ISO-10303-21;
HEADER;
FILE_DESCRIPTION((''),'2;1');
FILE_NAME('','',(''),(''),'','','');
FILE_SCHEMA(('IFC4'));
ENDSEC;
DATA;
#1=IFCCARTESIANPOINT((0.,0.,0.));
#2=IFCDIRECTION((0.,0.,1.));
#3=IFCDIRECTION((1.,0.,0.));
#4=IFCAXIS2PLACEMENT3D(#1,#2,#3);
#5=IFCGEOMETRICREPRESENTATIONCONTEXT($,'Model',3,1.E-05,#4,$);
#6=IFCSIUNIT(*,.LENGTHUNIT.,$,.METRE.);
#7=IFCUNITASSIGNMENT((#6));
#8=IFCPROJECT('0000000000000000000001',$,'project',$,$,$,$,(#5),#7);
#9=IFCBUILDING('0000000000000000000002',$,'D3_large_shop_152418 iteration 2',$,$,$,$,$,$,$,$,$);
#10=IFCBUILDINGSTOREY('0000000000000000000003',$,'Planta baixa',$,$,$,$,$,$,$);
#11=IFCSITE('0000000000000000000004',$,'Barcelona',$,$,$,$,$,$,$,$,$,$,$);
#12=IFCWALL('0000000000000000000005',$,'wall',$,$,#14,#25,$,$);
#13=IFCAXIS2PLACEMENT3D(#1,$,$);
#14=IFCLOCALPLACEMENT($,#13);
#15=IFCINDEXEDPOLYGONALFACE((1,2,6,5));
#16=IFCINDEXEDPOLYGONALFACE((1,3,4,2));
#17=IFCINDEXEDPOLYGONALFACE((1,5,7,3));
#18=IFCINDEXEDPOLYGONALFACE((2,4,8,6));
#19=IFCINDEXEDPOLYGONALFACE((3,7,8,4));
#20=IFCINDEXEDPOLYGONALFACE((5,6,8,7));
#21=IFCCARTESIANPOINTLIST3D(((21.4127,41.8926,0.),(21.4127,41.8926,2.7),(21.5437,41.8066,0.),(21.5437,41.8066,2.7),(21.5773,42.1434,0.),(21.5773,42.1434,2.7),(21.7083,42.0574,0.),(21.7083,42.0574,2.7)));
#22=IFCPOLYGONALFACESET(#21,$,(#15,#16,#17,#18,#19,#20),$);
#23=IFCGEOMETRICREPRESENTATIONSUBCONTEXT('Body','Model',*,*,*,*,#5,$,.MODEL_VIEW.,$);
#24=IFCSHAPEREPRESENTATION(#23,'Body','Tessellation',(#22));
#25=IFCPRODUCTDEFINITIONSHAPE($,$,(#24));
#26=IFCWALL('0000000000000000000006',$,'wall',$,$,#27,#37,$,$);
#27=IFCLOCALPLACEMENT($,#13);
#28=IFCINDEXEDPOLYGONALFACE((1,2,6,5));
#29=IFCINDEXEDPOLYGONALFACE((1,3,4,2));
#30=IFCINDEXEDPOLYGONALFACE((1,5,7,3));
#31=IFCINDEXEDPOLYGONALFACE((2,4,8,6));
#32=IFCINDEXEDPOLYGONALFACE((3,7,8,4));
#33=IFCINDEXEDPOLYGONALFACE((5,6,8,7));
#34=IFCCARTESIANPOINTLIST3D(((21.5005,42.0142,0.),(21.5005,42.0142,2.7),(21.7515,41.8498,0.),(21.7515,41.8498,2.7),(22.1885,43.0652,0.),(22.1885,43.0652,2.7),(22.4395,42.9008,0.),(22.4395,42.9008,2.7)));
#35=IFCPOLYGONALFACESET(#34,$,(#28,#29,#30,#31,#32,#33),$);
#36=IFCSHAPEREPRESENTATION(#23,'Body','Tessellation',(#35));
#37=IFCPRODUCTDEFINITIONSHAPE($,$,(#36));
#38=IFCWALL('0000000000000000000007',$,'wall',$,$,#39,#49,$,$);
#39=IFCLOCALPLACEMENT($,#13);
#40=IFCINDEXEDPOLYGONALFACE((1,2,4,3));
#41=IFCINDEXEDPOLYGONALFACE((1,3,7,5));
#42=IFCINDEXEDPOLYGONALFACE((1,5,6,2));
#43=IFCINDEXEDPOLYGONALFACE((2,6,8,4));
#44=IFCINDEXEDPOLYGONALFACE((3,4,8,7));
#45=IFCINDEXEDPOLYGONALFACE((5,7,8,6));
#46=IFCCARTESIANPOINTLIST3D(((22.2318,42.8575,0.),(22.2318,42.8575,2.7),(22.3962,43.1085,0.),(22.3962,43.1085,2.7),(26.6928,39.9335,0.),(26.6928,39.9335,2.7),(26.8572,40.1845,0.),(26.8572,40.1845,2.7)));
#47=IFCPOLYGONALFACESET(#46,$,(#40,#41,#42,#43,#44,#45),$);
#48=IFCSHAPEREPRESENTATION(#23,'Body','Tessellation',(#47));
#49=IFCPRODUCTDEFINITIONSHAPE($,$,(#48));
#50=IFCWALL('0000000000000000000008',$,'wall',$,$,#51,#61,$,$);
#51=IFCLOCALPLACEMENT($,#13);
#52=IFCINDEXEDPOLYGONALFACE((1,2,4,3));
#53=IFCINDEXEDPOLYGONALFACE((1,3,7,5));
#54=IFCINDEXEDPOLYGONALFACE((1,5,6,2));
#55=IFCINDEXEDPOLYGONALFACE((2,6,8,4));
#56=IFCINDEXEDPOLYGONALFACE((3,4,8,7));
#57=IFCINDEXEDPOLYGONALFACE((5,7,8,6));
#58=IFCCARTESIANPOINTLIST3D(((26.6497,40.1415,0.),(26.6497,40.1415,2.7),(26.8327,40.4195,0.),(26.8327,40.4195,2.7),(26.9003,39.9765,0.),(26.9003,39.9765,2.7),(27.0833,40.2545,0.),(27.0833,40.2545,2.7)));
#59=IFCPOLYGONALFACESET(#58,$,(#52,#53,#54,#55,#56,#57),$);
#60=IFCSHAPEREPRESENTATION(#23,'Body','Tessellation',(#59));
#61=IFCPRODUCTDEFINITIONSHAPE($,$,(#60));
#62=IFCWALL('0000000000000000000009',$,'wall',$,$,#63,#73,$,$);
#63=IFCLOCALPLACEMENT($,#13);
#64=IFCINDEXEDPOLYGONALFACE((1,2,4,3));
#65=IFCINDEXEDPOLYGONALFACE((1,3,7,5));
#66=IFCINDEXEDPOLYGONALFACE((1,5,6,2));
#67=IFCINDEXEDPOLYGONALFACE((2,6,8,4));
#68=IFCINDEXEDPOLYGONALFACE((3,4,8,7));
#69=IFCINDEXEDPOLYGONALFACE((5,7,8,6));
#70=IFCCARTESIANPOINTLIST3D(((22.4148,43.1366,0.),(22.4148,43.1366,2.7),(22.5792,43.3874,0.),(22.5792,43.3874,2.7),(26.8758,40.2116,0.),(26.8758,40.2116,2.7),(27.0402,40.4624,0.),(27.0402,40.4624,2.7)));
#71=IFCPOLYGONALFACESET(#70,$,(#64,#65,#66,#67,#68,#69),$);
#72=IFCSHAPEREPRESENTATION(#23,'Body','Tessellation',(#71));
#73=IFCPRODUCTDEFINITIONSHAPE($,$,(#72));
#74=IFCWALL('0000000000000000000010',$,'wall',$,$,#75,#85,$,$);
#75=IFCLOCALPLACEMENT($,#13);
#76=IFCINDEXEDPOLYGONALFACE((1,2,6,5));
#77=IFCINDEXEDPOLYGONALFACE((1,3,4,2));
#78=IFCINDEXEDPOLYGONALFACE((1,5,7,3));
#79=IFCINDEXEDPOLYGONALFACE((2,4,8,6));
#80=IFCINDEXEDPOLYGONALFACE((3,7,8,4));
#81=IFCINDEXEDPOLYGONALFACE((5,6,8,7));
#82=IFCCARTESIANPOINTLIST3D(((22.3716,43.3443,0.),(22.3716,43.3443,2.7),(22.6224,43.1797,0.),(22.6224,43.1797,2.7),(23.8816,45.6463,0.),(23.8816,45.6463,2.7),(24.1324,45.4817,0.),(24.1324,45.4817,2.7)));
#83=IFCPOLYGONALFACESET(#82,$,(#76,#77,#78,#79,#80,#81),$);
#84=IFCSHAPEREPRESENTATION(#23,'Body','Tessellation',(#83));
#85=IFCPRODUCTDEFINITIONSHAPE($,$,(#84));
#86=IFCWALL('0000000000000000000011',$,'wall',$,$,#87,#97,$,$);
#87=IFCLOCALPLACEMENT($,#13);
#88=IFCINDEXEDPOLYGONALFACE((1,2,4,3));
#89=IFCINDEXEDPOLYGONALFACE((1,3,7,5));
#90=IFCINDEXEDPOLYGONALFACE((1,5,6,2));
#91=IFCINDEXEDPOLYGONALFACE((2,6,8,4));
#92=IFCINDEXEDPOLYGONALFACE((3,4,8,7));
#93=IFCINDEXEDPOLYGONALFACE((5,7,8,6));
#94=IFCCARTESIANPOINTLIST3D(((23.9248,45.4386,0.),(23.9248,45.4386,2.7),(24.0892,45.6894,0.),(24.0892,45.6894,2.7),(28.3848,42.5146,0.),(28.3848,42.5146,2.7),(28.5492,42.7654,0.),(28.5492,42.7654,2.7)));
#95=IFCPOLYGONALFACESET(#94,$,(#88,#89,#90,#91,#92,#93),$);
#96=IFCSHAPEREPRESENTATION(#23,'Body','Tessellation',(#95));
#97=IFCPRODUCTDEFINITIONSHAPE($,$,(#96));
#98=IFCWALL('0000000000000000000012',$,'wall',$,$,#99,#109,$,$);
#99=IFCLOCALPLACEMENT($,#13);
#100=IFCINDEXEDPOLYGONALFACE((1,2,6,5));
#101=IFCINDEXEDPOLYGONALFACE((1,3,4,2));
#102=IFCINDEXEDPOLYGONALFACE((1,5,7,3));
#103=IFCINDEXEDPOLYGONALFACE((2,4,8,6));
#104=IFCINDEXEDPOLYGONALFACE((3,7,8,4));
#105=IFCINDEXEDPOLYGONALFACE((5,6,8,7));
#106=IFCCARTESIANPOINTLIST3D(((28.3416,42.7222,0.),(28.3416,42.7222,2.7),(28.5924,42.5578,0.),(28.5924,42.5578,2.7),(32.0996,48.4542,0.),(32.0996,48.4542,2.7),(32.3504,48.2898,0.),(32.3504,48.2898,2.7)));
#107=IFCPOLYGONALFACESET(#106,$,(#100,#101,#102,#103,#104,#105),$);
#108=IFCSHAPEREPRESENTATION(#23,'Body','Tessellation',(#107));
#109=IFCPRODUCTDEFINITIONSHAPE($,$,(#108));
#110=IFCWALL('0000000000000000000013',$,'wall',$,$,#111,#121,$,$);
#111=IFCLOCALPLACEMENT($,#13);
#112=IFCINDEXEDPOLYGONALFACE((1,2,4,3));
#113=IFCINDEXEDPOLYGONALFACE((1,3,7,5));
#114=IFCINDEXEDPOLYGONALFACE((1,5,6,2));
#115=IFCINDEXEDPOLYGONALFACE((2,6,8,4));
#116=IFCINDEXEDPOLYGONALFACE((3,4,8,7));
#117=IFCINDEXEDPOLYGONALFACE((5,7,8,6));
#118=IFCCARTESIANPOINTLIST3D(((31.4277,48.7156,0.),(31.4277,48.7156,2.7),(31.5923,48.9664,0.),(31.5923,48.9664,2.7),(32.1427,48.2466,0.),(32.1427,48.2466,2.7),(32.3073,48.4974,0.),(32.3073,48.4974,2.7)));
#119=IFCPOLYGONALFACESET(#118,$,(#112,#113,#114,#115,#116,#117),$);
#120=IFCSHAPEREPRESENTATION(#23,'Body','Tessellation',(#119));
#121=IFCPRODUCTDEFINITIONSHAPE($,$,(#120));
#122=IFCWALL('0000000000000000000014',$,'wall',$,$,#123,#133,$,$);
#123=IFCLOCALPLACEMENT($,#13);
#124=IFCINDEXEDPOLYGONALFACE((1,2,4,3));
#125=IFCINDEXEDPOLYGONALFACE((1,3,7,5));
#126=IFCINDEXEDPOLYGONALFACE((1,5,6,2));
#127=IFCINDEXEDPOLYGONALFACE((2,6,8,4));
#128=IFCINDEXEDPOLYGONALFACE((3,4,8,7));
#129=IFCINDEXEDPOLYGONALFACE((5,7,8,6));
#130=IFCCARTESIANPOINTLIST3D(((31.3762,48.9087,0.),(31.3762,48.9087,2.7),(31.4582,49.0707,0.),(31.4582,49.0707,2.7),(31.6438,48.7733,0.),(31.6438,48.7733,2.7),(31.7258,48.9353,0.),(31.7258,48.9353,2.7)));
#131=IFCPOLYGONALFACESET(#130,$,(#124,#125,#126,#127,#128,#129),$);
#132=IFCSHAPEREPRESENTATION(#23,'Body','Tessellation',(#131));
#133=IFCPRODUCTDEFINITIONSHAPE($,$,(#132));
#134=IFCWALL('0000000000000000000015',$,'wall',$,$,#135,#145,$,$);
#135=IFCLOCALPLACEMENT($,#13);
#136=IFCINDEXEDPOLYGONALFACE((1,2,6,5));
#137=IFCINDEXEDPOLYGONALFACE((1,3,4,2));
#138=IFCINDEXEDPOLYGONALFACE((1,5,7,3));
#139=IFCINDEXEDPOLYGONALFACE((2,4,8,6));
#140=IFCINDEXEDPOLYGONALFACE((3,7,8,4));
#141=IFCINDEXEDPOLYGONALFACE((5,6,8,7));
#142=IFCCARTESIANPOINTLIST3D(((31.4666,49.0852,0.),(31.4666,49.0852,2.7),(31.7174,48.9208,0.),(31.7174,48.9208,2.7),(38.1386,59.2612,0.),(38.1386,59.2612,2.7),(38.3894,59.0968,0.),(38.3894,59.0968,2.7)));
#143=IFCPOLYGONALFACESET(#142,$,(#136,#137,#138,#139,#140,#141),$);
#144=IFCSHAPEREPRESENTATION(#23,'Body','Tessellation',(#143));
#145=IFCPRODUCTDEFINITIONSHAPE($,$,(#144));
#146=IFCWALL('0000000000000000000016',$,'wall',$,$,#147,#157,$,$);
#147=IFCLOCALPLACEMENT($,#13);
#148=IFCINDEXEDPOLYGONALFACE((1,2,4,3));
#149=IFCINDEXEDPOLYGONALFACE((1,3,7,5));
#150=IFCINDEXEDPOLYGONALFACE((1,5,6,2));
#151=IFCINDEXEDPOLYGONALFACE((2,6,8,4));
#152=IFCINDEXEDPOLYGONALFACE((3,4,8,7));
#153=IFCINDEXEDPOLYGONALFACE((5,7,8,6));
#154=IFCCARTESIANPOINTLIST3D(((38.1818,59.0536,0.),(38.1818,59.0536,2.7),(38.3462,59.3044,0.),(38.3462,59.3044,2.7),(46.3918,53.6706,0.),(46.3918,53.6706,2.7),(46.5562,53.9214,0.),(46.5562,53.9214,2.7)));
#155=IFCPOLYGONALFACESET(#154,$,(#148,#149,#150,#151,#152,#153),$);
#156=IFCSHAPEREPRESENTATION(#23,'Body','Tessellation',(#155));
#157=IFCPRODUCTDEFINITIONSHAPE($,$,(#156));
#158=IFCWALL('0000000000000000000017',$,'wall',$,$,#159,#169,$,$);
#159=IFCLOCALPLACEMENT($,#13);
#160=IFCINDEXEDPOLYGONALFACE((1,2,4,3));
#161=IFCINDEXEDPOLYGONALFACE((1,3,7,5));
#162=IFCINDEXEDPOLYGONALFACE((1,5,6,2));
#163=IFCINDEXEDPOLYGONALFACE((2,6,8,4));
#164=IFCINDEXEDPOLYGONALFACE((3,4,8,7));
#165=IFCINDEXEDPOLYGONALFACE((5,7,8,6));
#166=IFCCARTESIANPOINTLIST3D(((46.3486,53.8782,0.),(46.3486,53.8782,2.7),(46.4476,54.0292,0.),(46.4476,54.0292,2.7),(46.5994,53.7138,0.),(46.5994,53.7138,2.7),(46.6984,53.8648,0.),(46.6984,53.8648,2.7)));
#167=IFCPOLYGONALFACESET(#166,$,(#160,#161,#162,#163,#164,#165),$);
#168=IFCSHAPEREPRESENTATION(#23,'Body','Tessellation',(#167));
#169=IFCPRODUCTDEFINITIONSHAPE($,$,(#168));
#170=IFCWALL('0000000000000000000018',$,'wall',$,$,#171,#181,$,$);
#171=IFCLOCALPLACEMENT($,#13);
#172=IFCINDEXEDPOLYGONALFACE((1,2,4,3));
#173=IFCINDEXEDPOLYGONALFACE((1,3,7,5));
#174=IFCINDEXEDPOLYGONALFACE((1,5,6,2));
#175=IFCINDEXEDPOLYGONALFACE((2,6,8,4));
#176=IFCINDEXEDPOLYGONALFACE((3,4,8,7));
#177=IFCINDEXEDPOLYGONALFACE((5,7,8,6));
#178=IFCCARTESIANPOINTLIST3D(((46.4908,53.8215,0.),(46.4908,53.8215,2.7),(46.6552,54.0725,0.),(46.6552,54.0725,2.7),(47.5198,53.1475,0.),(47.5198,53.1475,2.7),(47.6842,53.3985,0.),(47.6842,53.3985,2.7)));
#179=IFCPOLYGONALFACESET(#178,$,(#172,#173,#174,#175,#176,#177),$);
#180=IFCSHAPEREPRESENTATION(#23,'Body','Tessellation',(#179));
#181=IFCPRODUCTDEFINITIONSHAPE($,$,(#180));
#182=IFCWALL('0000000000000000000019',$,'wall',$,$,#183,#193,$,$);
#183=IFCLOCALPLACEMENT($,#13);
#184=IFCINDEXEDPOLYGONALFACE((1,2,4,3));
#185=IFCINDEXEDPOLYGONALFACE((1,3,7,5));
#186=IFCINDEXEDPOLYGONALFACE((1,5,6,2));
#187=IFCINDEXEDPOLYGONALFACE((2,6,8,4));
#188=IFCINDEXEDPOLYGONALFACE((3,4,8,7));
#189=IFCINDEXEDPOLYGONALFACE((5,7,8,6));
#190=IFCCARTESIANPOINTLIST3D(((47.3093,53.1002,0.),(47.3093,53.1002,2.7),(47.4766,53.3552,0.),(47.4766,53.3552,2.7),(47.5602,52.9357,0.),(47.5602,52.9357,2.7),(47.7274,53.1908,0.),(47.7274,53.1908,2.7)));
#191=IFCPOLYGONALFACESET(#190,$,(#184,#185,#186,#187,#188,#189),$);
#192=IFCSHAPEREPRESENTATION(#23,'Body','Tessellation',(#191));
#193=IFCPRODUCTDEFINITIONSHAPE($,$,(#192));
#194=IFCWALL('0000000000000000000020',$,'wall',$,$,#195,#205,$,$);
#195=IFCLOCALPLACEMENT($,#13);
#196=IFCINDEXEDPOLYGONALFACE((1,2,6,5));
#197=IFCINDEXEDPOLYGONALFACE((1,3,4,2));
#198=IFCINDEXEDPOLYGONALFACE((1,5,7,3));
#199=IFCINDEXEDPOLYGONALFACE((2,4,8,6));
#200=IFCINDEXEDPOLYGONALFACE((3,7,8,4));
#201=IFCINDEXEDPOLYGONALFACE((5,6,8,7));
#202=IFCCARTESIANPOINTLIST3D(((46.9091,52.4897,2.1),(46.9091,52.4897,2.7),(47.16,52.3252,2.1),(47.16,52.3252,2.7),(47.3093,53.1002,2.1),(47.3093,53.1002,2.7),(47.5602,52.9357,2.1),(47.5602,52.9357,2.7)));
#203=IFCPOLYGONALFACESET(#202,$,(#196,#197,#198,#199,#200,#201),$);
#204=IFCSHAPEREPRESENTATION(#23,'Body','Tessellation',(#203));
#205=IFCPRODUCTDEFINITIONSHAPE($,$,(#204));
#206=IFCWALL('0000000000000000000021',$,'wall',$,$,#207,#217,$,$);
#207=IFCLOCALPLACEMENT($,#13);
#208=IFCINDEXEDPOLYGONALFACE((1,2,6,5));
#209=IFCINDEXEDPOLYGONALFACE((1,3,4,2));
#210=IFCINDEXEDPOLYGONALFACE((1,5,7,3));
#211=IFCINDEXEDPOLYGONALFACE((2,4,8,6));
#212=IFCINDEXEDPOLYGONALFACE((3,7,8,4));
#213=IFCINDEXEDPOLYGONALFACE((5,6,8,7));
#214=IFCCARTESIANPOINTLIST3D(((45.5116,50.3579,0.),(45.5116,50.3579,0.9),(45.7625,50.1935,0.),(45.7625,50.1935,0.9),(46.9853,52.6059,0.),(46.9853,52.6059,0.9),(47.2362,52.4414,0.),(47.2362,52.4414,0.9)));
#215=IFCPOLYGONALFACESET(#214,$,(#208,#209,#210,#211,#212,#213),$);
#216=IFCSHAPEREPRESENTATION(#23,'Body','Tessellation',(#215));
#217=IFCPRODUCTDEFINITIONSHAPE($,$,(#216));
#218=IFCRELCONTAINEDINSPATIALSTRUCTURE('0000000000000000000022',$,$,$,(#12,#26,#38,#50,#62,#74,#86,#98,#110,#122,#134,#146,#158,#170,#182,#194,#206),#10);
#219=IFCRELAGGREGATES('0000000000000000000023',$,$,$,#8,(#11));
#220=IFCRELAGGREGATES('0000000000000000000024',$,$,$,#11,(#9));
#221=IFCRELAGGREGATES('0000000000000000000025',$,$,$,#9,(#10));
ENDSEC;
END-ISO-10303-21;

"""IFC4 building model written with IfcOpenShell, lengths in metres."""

from ifc_helpers import new_model, si_unit, frame, origin, origin_with_axes, place, context, subcontext, project, spatial, polyline, outline, extrude, element, save


model = new_model("IFC4")

# Units and contexts
model_context = context("Model", 3, precision=1e-05, world=origin_with_axes())
body_context = subcontext(model_context, "Body", "Model", "MODEL_VIEW")
ifc_project = project(units=[si_unit("LENGTHUNIT", "METRE")], contexts=[model_context])

# Site, building, storey
site = spatial("IfcSite", under=ifc_project, Name="Barcelona")
building = spatial("IfcBuilding", under=site, Name="D3_large_shop_152418 iteration 2")
storey = spatial("IfcBuildingStorey", under=building, Name="Planta baixa")

# Walls
wall_1_placement = place(None, origin_with_axes())
element("IfcWall", 1, at=wall_1_placement, inside=storey, Name="wall", context=body_context, shape_type="SweptSolid", body=[
    extrude(outline(polyline([(21.5773, 42.1434), (21.7083, 42.0574), (21.5437, 41.8066), (21.4127, 41.8926), (21.5773, 42.1434)])), origin(), (0.0, 0.0, 1.0), 2.7),
])
wall_2_placement = place(None, origin_with_axes())
element("IfcWall", 2, at=wall_2_placement, inside=storey, Name="wall", context=body_context, shape_type="SweptSolid", body=[
    extrude(outline(polyline([(21.5005, 42.0142), (22.1885, 43.0652), (22.4395, 42.9008), (21.7515, 41.8498), (21.5005, 42.0142)])), origin(), (0.0, 0.0, 1.0), 2.7),
])
wall_3_placement = place(None, origin_with_axes())
element("IfcWall", 3, at=wall_3_placement, inside=storey, Name="wall", context=body_context, shape_type="SweptSolid", body=[
    extrude(outline(polyline([(22.3962, 43.1085), (26.8572, 40.1845), (26.6928, 39.9335), (22.2318, 42.8575), (22.3962, 43.1085)])), origin(), (0.0, 0.0, 1.0), 2.7),
])
wall_4_placement = place(None, origin_with_axes())
element("IfcWall", 4, at=wall_4_placement, inside=storey, Name="wall", context=body_context, shape_type="SweptSolid", body=[
    extrude(outline(polyline([(26.6497, 40.1415), (26.8327, 40.4195), (27.0833, 40.2545), (26.9003, 39.9765), (26.6497, 40.1415)])), origin(), (0.0, 0.0, 1.0), 2.7),
])
wall_5_placement = place(None, origin_with_axes())
element("IfcWall", 5, at=wall_5_placement, inside=storey, Name="wall", context=body_context, shape_type="SweptSolid", body=[
    extrude(outline(polyline([(26.8758, 40.2116), (22.4148, 43.1366), (22.5792, 43.3874), (27.0402, 40.4624), (26.8758, 40.2116)])), origin(), (0.0, 0.0, 1.0), 2.7),
])
wall_6_placement = place(None, origin_with_axes())
element("IfcWall", 6, at=wall_6_placement, inside=storey, Name="wall", context=body_context, shape_type="SweptSolid", body=[
    extrude(outline(polyline([(22.3716, 43.3443), (23.8816, 45.6463), (24.1324, 45.4817), (22.6224, 43.1797), (22.3716, 43.3443)])), origin(), (0.0, 0.0, 1.0), 2.7),
])
wall_7_placement = place(None, origin_with_axes())
element("IfcWall", 7, at=wall_7_placement, inside=storey, Name="wall", context=body_context, shape_type="SweptSolid", body=[
    extrude(outline(polyline([(24.0892, 45.6894), (28.5492, 42.7654), (28.3848, 42.5146), (23.9248, 45.4386), (24.0892, 45.6894)])), origin(), (0.0, 0.0, 1.0), 2.7),
])
wall_8_placement = place(None, origin_with_axes())
element("IfcWall", 8, at=wall_8_placement, inside=storey, Name="wall", context=body_context, shape_type="SweptSolid", body=[
    extrude(outline(polyline([(28.3416, 42.7222), (32.0996, 48.4542), (32.3504, 48.2898), (28.5924, 42.5578), (28.3416, 42.7222)])), origin(), (0.0, 0.0, 1.0), 2.7),
])
wall_9_placement = place(None, origin_with_axes())
element("IfcWall", 9, at=wall_9_placement, inside=storey, Name="wall", context=body_context, shape_type="SweptSolid", body=[
    extrude(outline(polyline([(32.1427, 48.2466), (31.4277, 48.7156), (31.5923, 48.9664), (32.3073, 48.4974), (32.1427, 48.2466)])), origin(), (0.0, 0.0, 1.0), 2.7),
])
wall_10_placement = place(None, origin_with_axes())
element("IfcWall", 10, at=wall_10_placement, inside=storey, Name="wall", context=body_context, shape_type="SweptSolid", body=[
    extrude(outline(polyline([(31.3762, 48.9087), (31.4582, 49.0707), (31.7258, 48.9353), (31.6438, 48.7733), (31.3762, 48.9087)])), origin(), (0.0, 0.0, 1.0), 2.7),
])
wall_11_placement = place(None, origin_with_axes())
element("IfcWall", 11, at=wall_11_placement, inside=storey, Name="wall", context=body_context, shape_type="SweptSolid", body=[
    extrude(outline(polyline([(31.4666, 49.0852), (38.1386, 59.2612), (38.3894, 59.0968), (31.7174, 48.9208), (31.4666, 49.0852)])), origin(), (0.0, 0.0, 1.0), 2.7),
])
wall_12_placement = place(None, origin_with_axes())
element("IfcWall", 12, at=wall_12_placement, inside=storey, Name="wall", context=body_context, shape_type="SweptSolid", body=[
    extrude(outline(polyline([(38.3462, 59.3044), (46.5562, 53.9214), (46.3918, 53.6706), (38.1818, 59.0536), (38.3462, 59.3044)])), origin(), (0.0, 0.0, 1.0), 2.7),
])
wall_13_placement = place(None, origin_with_axes())
element("IfcWall", 13, at=wall_13_placement, inside=storey, Name="wall", context=body_context, shape_type="SweptSolid", body=[
    extrude(outline(polyline([(46.3486, 53.8782), (46.4476, 54.0292), (46.6984, 53.8648), (46.5994, 53.7138), (46.3486, 53.8782)])), origin(), (0.0, 0.0, 1.0), 2.7),
])
wall_14_placement = place(None, origin_with_axes())
element("IfcWall", 14, at=wall_14_placement, inside=storey, Name="wall", context=body_context, shape_type="SweptSolid", body=[
    extrude(outline(polyline([(46.6552, 54.0725), (47.6842, 53.3985), (47.5198, 53.1475), (46.4908, 53.8215), (46.6552, 54.0725)])), origin(), (0.0, 0.0, 1.0), 2.7),
])
wall_15_placement = place(None, origin_with_axes())
element("IfcWall", 15, at=wall_15_placement, inside=storey, Name="wall", context=body_context, shape_type="SweptSolid", body=[
    extrude(outline(polyline([(47.7274, 53.1908), (47.5602, 52.9357), (47.3093, 53.1002), (47.4766, 53.3552), (47.7274, 53.1908)])), origin(), (0.0, 0.0, 1.0), 2.7),
])
wall_16_placement = place(None, origin_with_axes())
element("IfcWall", 16, at=wall_16_placement, inside=storey, Name="wall", context=body_context, shape_type="SweptSolid", body=[
    extrude(outline(polyline([(47.5602, 52.9357), (47.16, 52.3252), (46.9091, 52.4897), (47.3093, 53.1002), (47.5602, 52.9357)])), frame((0.0, 0.0, 2.1)), (0.0, 0.0, 1.0), 0.6),
])
wall_17_placement = place(None, origin_with_axes())
element("IfcWall", 17, at=wall_17_placement, inside=storey, Name="wall", context=body_context, shape_type="SweptSolid", body=[
    extrude(outline(polyline([(47.2362, 52.4414), (45.7625, 50.1935), (45.5116, 50.3579), (46.9853, 52.6059), (47.2362, 52.4414)])), origin(), (0.0, 0.0, 1.0), 0.9),
])

save(model, "model.ifc")
